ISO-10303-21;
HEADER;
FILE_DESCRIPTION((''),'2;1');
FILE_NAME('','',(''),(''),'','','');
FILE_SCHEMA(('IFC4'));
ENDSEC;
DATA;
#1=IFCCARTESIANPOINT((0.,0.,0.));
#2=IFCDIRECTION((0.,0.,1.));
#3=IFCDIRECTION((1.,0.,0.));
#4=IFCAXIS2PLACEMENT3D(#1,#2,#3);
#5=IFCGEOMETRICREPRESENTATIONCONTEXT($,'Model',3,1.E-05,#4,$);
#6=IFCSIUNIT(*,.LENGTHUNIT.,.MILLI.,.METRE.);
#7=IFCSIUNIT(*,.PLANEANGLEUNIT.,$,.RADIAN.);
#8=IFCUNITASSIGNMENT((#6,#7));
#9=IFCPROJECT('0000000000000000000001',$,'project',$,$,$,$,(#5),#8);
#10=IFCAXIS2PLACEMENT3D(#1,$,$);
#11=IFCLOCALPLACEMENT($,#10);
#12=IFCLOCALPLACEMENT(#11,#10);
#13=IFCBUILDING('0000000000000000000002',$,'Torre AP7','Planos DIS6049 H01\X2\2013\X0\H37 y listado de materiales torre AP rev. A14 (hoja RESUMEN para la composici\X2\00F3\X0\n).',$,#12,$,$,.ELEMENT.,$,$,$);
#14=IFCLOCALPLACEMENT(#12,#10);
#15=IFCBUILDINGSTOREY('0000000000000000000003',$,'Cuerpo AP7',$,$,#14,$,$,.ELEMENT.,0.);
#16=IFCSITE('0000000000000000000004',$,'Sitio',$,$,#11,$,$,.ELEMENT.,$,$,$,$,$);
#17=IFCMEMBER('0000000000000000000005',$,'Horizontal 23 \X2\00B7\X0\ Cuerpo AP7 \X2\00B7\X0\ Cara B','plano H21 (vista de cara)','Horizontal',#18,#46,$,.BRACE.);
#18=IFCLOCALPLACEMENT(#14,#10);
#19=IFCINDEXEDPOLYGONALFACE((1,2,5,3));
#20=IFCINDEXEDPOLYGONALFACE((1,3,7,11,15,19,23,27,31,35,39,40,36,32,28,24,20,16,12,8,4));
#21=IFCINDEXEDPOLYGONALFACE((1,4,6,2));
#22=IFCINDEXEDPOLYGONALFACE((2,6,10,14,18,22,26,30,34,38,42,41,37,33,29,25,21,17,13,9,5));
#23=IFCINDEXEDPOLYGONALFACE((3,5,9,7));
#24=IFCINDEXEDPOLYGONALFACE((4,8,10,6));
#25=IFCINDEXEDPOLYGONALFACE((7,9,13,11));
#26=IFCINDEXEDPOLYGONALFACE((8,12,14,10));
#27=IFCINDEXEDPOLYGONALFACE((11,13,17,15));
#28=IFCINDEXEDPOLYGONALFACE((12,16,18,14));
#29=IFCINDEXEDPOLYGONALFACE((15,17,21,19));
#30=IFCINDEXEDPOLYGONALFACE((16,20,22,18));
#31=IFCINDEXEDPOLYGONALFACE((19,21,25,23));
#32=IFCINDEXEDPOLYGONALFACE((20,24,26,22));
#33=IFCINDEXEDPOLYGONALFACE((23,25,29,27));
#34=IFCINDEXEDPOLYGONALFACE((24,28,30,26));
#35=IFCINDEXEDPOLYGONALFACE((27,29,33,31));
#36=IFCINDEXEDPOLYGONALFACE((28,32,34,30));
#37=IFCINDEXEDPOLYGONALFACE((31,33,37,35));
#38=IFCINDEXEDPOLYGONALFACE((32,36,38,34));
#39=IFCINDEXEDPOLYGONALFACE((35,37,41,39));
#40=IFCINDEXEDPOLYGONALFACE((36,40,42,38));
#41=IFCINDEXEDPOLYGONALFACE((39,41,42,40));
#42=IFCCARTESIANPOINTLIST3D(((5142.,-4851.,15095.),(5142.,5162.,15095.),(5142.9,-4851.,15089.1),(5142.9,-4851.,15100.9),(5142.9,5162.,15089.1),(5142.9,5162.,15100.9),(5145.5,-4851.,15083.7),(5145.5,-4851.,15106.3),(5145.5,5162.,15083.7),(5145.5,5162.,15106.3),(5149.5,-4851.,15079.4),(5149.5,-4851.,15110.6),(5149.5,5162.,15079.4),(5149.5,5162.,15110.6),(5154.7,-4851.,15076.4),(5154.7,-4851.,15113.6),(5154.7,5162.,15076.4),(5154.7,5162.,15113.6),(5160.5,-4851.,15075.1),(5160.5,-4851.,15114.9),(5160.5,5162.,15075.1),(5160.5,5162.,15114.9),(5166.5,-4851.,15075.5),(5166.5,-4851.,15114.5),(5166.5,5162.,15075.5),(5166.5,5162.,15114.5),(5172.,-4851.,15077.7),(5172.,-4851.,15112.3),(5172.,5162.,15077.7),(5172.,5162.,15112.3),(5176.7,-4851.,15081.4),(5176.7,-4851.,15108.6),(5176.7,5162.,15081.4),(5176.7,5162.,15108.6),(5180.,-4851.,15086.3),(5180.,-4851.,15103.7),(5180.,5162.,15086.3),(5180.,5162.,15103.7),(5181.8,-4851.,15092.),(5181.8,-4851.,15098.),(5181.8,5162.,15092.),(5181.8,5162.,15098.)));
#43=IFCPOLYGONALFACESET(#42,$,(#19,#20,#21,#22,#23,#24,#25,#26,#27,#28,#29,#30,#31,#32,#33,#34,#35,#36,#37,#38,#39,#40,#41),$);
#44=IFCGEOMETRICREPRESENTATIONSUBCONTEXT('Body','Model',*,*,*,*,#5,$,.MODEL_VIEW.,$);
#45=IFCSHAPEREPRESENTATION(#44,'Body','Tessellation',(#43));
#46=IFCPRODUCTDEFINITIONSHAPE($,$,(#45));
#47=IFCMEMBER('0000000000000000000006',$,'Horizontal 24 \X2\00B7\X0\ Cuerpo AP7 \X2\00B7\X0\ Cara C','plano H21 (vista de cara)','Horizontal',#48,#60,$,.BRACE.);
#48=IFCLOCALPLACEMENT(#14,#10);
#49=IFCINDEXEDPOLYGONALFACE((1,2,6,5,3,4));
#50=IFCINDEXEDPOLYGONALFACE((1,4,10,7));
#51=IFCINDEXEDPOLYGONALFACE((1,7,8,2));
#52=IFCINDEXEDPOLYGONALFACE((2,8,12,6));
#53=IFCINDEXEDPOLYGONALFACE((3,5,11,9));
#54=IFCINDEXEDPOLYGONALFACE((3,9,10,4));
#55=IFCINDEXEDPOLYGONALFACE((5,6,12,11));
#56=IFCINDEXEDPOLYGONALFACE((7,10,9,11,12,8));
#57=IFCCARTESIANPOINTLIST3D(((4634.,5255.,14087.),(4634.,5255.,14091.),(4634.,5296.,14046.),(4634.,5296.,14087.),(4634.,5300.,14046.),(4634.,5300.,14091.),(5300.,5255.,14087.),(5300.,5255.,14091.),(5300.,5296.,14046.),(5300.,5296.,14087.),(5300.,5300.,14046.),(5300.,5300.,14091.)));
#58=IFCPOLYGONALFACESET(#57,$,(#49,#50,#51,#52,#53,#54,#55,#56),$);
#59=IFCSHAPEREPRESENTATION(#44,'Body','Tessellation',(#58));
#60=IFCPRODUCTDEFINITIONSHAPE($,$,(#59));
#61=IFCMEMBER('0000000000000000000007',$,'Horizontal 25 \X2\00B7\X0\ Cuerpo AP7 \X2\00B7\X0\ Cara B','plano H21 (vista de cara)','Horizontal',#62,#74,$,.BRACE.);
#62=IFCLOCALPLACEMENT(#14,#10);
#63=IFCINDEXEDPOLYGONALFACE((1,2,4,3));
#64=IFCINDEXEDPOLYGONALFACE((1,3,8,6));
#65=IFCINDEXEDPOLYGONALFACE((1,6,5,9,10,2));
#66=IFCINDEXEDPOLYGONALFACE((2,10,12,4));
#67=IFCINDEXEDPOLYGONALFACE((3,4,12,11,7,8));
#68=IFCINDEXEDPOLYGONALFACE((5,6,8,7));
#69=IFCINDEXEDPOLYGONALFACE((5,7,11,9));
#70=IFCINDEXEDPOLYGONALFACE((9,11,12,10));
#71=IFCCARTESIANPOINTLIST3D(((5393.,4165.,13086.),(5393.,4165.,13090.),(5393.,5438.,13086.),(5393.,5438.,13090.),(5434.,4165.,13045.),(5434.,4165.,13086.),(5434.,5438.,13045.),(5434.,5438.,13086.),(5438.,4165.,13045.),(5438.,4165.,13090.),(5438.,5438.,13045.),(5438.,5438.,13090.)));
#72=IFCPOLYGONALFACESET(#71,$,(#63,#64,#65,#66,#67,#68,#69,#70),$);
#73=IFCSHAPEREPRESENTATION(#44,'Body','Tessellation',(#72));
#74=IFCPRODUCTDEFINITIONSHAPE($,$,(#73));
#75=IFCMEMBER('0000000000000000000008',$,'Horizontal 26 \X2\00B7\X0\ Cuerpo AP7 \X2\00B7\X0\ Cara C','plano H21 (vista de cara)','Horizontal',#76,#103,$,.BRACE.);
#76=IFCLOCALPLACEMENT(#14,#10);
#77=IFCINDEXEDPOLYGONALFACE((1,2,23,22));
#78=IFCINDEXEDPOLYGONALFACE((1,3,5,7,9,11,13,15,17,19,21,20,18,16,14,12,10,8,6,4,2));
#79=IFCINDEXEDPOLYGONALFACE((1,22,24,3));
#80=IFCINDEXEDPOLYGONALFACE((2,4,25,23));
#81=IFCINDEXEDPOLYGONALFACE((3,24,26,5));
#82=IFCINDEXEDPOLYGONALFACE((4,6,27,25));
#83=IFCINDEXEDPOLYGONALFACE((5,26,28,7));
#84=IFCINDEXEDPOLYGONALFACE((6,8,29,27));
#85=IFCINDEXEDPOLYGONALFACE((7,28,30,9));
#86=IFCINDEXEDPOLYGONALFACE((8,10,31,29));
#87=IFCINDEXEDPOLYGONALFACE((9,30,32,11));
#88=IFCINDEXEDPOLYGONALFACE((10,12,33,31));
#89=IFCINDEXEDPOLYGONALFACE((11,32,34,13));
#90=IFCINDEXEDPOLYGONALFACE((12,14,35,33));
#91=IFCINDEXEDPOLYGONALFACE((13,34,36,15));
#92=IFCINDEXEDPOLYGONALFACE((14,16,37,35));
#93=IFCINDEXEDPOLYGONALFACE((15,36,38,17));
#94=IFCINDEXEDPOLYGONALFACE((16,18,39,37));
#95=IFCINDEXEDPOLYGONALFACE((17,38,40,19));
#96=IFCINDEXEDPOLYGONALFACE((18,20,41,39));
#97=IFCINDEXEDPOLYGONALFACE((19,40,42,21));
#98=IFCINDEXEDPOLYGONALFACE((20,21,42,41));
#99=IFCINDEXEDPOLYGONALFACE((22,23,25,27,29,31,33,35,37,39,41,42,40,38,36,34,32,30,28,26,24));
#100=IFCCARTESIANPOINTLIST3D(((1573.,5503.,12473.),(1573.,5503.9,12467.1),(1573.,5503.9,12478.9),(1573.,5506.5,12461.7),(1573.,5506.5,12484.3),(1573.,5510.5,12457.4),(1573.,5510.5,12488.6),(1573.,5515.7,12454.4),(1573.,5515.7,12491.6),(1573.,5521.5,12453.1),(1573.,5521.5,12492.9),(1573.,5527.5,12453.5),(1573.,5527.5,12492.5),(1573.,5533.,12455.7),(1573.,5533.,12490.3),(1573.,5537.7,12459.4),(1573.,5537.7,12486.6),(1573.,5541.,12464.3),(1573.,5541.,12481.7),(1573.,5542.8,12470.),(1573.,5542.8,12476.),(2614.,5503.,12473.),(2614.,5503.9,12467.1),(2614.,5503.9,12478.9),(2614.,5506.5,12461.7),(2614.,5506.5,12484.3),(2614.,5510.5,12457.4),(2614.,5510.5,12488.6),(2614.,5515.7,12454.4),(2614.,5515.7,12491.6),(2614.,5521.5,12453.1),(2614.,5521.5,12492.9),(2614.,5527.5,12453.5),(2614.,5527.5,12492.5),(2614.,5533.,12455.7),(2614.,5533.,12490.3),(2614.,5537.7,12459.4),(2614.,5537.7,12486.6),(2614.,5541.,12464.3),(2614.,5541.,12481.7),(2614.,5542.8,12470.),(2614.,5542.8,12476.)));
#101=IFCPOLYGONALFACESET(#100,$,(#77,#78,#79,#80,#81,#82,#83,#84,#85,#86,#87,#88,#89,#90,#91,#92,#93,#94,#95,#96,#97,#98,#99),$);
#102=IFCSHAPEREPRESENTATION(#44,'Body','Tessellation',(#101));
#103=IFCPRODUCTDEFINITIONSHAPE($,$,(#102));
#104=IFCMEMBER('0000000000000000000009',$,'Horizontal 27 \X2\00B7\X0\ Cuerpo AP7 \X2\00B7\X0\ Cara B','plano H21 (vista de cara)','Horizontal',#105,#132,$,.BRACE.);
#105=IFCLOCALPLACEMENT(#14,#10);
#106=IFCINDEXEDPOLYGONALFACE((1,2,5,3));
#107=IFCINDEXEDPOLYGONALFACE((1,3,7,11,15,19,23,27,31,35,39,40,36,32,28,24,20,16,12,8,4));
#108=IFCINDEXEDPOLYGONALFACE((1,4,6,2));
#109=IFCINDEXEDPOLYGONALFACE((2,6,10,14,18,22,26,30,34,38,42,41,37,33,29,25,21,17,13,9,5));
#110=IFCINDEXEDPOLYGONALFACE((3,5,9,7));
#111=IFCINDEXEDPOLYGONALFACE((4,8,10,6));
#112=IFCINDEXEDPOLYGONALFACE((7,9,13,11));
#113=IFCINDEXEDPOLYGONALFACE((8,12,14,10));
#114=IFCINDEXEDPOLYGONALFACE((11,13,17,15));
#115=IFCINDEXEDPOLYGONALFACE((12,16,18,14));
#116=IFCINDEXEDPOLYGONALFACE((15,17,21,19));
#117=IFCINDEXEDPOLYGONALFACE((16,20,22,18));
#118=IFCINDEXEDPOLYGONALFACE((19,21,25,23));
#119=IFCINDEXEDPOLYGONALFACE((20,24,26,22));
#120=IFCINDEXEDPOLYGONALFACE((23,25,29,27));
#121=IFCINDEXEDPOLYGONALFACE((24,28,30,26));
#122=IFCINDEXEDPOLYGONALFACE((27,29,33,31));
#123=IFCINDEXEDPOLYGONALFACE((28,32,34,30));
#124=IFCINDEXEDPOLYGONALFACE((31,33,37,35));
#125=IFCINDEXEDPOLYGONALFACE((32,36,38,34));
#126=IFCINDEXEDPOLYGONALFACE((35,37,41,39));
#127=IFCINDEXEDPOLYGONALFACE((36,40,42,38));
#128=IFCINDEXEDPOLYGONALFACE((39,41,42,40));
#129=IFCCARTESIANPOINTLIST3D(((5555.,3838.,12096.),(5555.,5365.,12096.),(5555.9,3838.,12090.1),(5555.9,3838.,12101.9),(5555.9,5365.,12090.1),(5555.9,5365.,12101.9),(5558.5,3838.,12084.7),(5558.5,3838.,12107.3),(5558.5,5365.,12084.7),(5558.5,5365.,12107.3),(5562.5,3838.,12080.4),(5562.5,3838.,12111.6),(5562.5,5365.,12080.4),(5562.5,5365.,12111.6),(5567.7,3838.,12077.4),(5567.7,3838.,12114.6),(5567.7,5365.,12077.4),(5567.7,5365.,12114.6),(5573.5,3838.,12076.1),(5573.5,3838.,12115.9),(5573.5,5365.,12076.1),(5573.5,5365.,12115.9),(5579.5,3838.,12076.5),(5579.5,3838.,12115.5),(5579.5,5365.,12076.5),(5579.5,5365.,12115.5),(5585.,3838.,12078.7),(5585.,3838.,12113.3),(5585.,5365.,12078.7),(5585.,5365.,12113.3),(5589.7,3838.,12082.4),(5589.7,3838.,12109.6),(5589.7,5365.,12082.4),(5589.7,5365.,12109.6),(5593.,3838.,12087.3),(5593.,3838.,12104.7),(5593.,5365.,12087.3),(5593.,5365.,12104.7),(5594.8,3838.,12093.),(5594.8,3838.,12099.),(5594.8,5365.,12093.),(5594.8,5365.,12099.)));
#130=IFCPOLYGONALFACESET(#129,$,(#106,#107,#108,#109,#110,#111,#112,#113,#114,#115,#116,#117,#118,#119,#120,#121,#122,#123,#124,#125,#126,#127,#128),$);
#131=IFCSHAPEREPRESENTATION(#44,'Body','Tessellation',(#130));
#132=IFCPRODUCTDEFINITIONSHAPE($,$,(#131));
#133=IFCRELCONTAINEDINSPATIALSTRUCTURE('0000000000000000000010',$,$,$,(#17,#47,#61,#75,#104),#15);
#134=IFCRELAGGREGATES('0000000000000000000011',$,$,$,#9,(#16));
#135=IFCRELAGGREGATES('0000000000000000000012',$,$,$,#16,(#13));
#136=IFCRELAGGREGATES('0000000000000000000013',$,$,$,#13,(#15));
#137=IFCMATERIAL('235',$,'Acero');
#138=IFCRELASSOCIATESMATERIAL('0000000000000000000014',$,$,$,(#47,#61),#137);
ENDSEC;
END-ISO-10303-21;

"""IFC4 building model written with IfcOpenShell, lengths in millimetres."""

from ifc_helpers import new_model, si_unit, frame, frame_2d, origin, origin_with_axes, place, context, subcontext, project, spatial, circle, l_section, extrude, material, element, save


model = new_model("IFC4")

# Units and contexts
model_context = context("Model", 3, precision=1e-05, world=origin_with_axes())
body_context = subcontext(model_context, "Body", "Model", "MODEL_VIEW")
ifc_project = project(units=[si_unit("LENGTHUNIT", "METRE", prefix="MILLI"), si_unit("PLANEANGLEUNIT", "RADIAN")], contexts=[model_context])

# Site, building, storey
site_placement = place(None, origin())
site = spatial("IfcSite", under=ifc_project, at=site_placement, Name="Sitio", CompositionType="ELEMENT")
building_placement = place(site_placement, origin())
building = spatial("IfcBuilding", under=site, at=building_placement, Name="Torre AP7", Description="Planos DIS6049 H01–H37 y listado de materiales torre AP rev. A14 (hoja RESUMEN para la composición).", CompositionType="ELEMENT")
storey_placement = place(building_placement, origin())
storey = spatial("IfcBuildingStorey", under=building, at=storey_placement, Name="Cuerpo AP7", CompositionType="ELEMENT", Elevation=0.0)

# Members
ifc_material_1 = material(Name="235", Category="Acero")
member_1_placement = place(storey_placement, frame((5162.0, 5162.0, 15095.0), z_axis=(0.0, -1.0, 0.0), x_axis=(-1.0, 0.0, 0.0)))
element("IfcMember", 1, at=member_1_placement, inside=storey, Name="Horizontal 23 · Cuerpo AP7 · Cara B", Description="plano H21 (vista de cara)", ObjectType="Horizontal", PredefinedType="BRACE", context=body_context, shape_type="SweptSolid", body=[
    extrude(circle(Radius=20.0), None, (0.0, 0.0, 1.0), 10013.0),
])
member_2_placement = place(storey_placement, frame((4634.0, 5300.0, 14091.0), z_axis=(1.0, 0.0, 0.0), x_axis=(0.0, -1.0, 0.0)))
element("IfcMember", 2, at=member_2_placement, inside=storey, material=ifc_material_1, Name="Horizontal 24 · Cuerpo AP7 · Cara C", Description="plano H21 (vista de cara)", ObjectType="Horizontal", PredefinedType="BRACE", context=body_context, shape_type="SweptSolid", body=[
    extrude(l_section(Depth=45.0, Width=45.0, Thickness=4.0, at=frame_2d((22.5, 22.5))), None, (0.0, 0.0, 1.0), 666.0),
])
member_3_placement = place(storey_placement, frame((5438.0, 5438.0, 13090.0), z_axis=(0.0, -1.0, 0.0), x_axis=(-1.0, 0.0, 0.0)))
element("IfcMember", 3, at=member_3_placement, inside=storey, material=ifc_material_1, Name="Horizontal 25 · Cuerpo AP7 · Cara B", Description="plano H21 (vista de cara)", ObjectType="Horizontal", PredefinedType="BRACE", context=body_context, shape_type="SweptSolid", body=[
    extrude(l_section(Depth=45.0, Width=45.0, Thickness=4.0, at=frame_2d((22.5, 22.5))), None, (0.0, 0.0, 1.0), 1273.0),
])
member_4_placement = place(storey_placement, frame((1573.0, 5523.0, 12473.0), z_axis=(1.0, 0.0, 0.0), x_axis=(0.0, -1.0, 0.0)))
element("IfcMember", 4, at=member_4_placement, inside=storey, Name="Horizontal 26 · Cuerpo AP7 · Cara C", Description="plano H21 (vista de cara)", ObjectType="Horizontal", PredefinedType="BRACE", context=body_context, shape_type="SweptSolid", body=[
    extrude(circle(Radius=20.0), None, (0.0, 0.0, 1.0), 1041.0),
])
member_5_placement = place(storey_placement, frame((5575.0, 5365.0, 12096.0), z_axis=(0.0, -1.0, 0.0), x_axis=(-1.0, 0.0, 0.0)))
element("IfcMember", 5, at=member_5_placement, inside=storey, Name="Horizontal 27 · Cuerpo AP7 · Cara B", Description="plano H21 (vista de cara)", ObjectType="Horizontal", PredefinedType="BRACE", context=body_context, shape_type="SweptSolid", body=[
    extrude(circle(Radius=20.0), None, (0.0, 0.0, 1.0), 1527.0),
])

save(model, "model.ifc")
